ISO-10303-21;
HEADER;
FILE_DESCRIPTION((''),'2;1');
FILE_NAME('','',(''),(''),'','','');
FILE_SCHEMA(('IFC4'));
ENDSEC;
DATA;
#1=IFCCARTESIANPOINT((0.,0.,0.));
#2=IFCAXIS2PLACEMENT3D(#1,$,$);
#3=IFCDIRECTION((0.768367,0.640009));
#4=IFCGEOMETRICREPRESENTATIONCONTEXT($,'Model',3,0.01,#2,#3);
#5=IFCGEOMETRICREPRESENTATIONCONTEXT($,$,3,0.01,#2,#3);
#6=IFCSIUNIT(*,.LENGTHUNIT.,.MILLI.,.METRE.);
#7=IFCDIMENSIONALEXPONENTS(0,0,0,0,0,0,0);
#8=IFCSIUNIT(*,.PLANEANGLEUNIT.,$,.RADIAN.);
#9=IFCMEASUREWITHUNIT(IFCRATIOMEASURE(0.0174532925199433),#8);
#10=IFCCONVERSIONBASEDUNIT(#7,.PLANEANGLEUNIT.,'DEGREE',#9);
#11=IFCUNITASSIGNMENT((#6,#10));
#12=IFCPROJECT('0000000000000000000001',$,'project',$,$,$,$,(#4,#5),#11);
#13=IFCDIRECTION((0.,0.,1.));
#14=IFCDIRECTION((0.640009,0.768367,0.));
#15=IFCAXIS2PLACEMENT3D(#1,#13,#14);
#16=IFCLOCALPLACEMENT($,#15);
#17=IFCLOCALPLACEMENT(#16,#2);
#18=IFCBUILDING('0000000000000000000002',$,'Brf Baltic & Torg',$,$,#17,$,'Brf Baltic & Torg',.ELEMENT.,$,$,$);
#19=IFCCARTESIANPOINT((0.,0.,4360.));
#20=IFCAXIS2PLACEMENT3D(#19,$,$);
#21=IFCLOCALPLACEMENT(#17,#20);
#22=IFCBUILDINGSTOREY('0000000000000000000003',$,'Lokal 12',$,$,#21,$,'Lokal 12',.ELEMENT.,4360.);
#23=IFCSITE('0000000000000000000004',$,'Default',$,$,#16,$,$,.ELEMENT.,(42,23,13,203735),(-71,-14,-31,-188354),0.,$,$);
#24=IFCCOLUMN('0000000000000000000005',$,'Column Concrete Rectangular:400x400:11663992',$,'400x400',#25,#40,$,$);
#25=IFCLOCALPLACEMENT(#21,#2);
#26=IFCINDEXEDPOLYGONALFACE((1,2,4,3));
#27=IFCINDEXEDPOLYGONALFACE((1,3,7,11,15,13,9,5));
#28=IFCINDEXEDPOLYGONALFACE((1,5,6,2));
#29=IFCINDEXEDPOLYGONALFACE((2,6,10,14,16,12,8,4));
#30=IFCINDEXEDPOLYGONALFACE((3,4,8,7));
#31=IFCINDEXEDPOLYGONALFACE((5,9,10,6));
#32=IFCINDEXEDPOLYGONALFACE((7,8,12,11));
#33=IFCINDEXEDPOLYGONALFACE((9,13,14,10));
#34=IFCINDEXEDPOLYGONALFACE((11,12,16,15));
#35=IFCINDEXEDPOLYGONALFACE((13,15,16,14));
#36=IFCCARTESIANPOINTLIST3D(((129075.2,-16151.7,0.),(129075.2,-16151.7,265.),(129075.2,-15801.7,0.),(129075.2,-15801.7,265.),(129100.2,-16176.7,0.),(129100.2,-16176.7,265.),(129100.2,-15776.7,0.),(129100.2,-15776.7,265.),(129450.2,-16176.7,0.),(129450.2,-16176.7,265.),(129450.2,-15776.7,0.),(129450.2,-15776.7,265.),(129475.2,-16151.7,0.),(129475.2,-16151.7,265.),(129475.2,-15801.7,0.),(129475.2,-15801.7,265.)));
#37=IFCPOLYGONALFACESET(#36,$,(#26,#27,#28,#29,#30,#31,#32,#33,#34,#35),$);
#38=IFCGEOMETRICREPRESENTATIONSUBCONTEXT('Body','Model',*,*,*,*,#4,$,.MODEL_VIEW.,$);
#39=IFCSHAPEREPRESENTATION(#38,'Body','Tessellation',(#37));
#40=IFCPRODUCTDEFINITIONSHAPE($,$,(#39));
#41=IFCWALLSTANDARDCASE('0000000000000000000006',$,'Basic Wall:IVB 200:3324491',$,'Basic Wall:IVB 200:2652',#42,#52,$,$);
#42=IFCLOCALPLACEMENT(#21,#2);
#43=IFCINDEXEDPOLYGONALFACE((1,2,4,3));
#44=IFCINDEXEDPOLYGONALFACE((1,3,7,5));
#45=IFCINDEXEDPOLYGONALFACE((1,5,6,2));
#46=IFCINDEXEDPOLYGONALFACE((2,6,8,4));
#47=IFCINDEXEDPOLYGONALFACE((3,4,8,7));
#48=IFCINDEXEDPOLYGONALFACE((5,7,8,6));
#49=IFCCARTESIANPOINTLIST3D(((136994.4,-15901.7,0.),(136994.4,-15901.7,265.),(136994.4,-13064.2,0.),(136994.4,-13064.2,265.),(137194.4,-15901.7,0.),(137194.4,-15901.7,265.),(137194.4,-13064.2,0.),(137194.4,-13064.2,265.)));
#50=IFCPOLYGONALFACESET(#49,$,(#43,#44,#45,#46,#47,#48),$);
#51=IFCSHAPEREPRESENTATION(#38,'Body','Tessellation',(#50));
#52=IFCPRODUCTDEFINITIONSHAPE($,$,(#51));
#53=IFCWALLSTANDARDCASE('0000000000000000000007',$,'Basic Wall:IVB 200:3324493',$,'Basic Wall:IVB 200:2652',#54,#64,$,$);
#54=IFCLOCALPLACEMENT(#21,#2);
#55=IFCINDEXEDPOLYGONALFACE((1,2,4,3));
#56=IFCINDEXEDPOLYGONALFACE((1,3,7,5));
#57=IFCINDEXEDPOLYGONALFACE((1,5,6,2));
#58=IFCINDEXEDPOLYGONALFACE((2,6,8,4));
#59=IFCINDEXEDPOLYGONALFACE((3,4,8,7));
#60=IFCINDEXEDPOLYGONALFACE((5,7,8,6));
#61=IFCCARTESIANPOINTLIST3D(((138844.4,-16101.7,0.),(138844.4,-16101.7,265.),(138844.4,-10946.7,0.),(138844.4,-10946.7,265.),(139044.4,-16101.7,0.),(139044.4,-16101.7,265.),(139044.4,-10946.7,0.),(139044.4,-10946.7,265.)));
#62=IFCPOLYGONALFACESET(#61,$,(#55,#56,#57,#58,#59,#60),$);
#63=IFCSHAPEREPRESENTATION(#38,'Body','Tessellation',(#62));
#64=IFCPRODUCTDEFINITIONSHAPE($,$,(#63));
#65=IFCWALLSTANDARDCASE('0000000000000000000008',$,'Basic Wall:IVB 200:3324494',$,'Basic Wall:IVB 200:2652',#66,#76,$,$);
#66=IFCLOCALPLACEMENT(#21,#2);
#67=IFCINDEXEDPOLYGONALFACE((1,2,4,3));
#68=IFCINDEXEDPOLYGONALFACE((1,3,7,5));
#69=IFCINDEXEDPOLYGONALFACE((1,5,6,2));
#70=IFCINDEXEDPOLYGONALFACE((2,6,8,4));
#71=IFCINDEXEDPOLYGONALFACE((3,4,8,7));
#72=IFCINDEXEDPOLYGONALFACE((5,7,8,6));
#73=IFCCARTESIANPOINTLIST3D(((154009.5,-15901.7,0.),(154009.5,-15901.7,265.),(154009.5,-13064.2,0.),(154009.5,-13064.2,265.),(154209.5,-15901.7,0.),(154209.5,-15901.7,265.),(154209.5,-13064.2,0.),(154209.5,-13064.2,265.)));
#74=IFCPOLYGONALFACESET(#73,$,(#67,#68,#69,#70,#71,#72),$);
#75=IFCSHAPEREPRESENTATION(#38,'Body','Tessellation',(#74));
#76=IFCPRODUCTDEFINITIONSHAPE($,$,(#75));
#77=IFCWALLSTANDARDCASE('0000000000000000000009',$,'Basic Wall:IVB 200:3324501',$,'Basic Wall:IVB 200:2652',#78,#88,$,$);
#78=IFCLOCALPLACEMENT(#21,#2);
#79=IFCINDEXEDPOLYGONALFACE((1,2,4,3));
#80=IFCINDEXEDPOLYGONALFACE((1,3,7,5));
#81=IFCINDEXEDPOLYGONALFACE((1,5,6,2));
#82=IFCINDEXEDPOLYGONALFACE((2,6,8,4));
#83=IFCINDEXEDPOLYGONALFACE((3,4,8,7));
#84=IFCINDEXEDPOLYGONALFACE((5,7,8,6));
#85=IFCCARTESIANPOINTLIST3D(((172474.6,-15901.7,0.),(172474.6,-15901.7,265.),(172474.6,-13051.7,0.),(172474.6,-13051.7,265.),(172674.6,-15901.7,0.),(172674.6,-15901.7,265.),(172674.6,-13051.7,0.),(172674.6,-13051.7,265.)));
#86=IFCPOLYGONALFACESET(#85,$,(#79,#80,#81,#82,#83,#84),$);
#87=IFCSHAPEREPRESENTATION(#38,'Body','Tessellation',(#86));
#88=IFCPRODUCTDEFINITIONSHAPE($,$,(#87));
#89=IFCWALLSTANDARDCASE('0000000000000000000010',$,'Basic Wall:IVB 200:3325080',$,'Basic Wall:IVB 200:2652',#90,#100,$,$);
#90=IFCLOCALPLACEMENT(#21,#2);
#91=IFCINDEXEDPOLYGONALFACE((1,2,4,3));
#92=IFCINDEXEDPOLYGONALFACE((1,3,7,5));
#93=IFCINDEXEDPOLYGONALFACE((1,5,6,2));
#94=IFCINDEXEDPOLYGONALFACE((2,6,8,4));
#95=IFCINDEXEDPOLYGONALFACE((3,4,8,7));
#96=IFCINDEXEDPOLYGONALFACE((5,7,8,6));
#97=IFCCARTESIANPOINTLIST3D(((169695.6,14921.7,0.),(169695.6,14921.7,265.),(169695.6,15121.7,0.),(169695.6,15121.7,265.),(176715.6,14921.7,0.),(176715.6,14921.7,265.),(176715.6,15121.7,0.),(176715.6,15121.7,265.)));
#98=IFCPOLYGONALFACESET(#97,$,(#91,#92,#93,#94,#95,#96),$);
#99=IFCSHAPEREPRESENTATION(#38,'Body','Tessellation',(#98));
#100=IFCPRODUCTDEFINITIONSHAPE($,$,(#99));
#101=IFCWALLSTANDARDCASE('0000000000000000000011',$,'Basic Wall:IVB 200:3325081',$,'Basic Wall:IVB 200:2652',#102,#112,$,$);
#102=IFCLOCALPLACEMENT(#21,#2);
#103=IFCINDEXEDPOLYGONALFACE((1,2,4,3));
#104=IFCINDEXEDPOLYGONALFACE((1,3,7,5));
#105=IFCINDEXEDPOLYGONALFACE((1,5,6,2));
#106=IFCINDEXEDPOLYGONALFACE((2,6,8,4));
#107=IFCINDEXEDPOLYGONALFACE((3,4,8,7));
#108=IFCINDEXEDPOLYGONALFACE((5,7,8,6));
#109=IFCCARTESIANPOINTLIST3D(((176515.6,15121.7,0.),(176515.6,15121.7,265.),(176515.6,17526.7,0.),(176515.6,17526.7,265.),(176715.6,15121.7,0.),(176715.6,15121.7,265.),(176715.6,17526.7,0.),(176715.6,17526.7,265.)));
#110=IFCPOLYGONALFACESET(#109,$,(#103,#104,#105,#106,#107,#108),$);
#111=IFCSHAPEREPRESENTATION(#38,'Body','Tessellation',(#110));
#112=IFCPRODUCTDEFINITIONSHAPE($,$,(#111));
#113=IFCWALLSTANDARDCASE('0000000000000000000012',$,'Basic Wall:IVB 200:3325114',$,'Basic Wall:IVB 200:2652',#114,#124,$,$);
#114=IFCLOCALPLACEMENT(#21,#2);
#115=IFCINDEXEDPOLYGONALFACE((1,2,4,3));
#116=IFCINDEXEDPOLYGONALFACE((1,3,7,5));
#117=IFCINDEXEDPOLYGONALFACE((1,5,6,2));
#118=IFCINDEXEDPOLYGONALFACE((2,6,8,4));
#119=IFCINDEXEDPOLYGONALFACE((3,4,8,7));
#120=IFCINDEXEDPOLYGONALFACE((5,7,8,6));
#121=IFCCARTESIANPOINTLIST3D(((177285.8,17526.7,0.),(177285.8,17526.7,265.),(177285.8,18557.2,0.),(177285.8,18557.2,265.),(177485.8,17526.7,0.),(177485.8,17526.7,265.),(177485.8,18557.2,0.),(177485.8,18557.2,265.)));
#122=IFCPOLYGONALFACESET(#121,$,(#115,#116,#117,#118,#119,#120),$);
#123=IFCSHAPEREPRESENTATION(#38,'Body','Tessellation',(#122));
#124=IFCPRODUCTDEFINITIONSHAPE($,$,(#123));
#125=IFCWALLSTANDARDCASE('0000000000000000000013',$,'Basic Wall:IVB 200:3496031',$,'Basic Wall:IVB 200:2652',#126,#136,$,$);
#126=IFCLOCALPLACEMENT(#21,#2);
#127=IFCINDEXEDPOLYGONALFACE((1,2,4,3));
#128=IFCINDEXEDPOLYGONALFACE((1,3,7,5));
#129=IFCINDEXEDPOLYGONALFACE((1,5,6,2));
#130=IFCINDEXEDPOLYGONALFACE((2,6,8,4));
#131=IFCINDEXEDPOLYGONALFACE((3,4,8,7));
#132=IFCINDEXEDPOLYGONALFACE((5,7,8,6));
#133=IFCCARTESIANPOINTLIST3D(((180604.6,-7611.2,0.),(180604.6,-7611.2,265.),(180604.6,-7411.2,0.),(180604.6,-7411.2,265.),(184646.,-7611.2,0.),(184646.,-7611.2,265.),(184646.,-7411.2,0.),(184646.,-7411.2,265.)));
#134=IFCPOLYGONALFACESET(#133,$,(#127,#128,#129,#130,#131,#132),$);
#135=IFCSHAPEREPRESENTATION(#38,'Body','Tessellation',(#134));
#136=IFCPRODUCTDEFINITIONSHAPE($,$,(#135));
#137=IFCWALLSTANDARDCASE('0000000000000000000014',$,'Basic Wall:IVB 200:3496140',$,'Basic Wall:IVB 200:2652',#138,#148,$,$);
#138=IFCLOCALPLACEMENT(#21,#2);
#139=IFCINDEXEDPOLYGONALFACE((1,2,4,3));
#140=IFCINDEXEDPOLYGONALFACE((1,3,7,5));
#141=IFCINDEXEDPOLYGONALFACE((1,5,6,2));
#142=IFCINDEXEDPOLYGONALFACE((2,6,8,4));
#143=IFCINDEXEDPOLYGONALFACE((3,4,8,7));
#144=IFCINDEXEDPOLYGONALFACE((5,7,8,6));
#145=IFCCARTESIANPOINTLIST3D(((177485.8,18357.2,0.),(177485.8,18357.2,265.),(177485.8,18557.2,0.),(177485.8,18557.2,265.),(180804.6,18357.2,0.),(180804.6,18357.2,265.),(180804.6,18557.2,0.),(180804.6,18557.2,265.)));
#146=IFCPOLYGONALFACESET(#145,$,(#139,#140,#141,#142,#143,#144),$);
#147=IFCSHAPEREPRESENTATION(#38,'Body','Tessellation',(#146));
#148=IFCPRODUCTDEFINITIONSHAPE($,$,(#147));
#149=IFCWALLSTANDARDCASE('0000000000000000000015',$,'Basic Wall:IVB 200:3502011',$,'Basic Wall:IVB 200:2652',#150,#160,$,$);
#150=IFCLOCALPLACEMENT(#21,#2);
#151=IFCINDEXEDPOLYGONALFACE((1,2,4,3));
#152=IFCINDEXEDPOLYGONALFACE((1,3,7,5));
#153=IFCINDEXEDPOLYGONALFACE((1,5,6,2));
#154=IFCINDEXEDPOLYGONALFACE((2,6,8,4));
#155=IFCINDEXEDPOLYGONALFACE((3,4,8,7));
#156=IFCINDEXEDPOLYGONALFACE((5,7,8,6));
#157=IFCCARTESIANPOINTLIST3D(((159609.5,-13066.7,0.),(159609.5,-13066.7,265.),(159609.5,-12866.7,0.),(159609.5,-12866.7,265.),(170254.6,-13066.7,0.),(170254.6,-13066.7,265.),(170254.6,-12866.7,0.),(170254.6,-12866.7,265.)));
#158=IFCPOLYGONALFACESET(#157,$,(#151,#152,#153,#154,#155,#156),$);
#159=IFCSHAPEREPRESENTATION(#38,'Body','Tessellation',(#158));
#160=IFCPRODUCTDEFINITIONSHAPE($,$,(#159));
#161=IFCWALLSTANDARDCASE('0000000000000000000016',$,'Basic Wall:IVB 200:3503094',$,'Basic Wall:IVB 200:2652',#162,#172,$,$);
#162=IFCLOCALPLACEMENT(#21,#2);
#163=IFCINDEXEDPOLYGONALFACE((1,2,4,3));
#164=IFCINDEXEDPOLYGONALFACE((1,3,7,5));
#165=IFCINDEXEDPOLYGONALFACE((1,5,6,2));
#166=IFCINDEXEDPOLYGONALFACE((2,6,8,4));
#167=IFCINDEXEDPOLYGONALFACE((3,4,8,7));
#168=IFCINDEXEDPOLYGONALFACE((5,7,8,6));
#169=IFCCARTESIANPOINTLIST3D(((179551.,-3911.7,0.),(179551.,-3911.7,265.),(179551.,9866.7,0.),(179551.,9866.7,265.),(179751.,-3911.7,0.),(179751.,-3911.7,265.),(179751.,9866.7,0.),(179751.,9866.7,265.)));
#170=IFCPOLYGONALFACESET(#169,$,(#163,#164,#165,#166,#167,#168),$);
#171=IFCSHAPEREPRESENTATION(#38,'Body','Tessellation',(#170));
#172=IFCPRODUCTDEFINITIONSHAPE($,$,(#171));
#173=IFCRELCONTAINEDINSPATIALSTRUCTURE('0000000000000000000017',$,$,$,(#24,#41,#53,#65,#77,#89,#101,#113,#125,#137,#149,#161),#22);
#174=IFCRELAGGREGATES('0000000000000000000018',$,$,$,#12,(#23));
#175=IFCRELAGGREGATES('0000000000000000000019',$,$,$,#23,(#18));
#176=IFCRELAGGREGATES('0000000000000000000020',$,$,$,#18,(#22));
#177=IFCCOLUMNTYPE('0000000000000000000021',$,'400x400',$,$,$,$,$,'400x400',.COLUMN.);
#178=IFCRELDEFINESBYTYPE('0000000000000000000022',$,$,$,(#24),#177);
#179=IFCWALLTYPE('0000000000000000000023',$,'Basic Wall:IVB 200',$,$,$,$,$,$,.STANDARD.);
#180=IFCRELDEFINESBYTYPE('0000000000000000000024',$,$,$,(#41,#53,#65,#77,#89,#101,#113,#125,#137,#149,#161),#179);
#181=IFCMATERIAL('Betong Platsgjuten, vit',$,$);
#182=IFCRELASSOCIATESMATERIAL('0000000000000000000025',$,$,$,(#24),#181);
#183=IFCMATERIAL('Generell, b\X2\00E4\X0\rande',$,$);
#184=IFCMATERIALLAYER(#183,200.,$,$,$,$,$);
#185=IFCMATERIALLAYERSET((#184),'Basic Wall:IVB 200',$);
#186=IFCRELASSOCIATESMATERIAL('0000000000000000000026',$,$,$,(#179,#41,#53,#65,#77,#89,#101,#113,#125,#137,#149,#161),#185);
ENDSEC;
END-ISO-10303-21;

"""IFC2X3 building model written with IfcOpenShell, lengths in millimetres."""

from ifc_helpers import new_model, entity, si_unit, converted_unit, direction, frame, frame_2d, origin, place, context, subcontext, project, spatial, polyline, rectangle, outline, extrude, clip, halfspace, source, transform, mapped, material, layer, layer_set, layer_usage, type_object, type_shapes, element, save


model = new_model("IFC2X3")

# Units and contexts
model_context = context("Model", 3, precision=0.01, world=origin(), true_north=direction((0.768367, 0.640009)))
context_of_model = context(None, 3, precision=0.01, world=origin(), true_north=direction((0.768367, 0.640009)))
body_context = subcontext(model_context, "Body", "Model", "MODEL_VIEW")
ifc_project = project(units=[si_unit("LENGTHUNIT", "METRE", prefix="MILLI"), converted_unit("PLANEANGLEUNIT", "DEGREE", entity("IfcRatioMeasure", 0.0174532925199433), si_unit("PLANEANGLEUNIT", "RADIAN"), dimensions=[0, 0, 0, 0, 0, 0, 0])], contexts=[model_context, context_of_model])

# Site, building, storey
site_placement = place(None, frame((0.0, 0.0, 0.0), z_axis=(0.0, 0.0, 1.0), x_axis=(0.640009, 0.768367, 0.0)))
site = spatial("IfcSite", under=ifc_project, at=site_placement, Name="Default", CompositionType="ELEMENT", RefLatitude=(42, 23, 13, 203735), RefLongitude=(-71, -14, -31, -188354), RefElevation=0.0)
building_placement = place(site_placement, origin())
building = spatial("IfcBuilding", under=site, at=building_placement, Name="Brf Baltic & Torg", LongName="Brf Baltic & Torg", CompositionType="ELEMENT")
storey_placement = place(building_placement, frame((0.0, 0.0, 4360.0)))
storey = spatial("IfcBuildingStorey", under=building, at=storey_placement, Name="Lokal 12", LongName="Lokal 12", CompositionType="ELEMENT", Elevation=4360.0)

# Column
ifc_material_1 = material(Name="Betong Platsgjuten, vit")
column_type = type_object("IfcColumnType", Name="400x400", ElementType="400x400", PredefinedType="COLUMN")
shared_shape = source(origin(), body_context, "Body", "SweptSolid", [
    extrude(outline(polyline([(-175.0, -200.0), (175.0, -200.0), (200.0, -175.0), (200.0, 175.0), (175.0, 200.0), (-175.0, 200.0), (-200.0, 175.0), (-200.0, -175.0), (-175.0, -200.0)])), frame((0.0, 0.0, 4360.0), z_axis=(0.0, 0.0, 1.0), x_axis=(0.0, -1.0, 0.0)), (0.0, 0.0, 1.0), 265.0),
])
type_shapes(column_type, [shared_shape])
column_placement = place(storey_placement, frame((129275.2, -15976.7, -4360.0)))
element("IfcColumn", 1, at=column_placement, inside=storey, type_object=column_type, material=ifc_material_1, Name="Column Concrete Rectangular:400x400:11663992", ObjectType="400x400", context=body_context, shape_type="MappedRepresentation", body=[
    mapped(shared_shape, transform((0.0, 0.0, 0.0), scale=1.0)),
])

# Shared definitions
ifc_material_2 = material(Name="Generell, bärande")
ifc_layer_1 = layer(ifc_material_2, 200.0)
ifc_layer_set_1 = layer_set([ifc_layer_1], Name="Basic Wall:IVB 200")
wall_type_1 = type_object("IfcWallType", Name="Basic Wall:IVB 200", PredefinedType="STANDARD", material=ifc_layer_set_1)

# Walls
ifc_layer_usage_1 = layer_usage(ifc_layer_set_1, "AXIS2", "NEGATIVE", 100.0)
wall_1_placement = place(storey_placement, frame((137094.4, -15901.7, 0.0), z_axis=(0.0, 0.0, 1.0), x_axis=(0.0, 1.0, 0.0)))
element("IfcWallStandardCase", 2, at=wall_1_placement, inside=storey, type_object=wall_type_1, material=ifc_layer_usage_1, Name="Basic Wall:IVB 200:3324491", ObjectType="Basic Wall:IVB 200:2652", context=body_context, shape_type="Clipping", body=[
    clip(extrude(rectangle(XDim=2837.5, YDim=200.0, at=frame_2d((1418.8, 0.0), x_axis=(-1.0, 0.0))), origin(), (0.0, 0.0, 1.0), 265.0), halfspace(frame((0.0, 0.0, -2710.0)), True)),
])
ifc_layer_usage_2 = layer_usage(ifc_layer_set_1, "AXIS2", "NEGATIVE", 100.0)
wall_2_placement = place(storey_placement, frame((138944.4, -10946.7, 0.0), z_axis=(0.0, 0.0, 1.0), x_axis=(0.0, -1.0, 0.0)))
element("IfcWallStandardCase", 3, at=wall_2_placement, inside=storey, type_object=wall_type_1, material=ifc_layer_usage_2, Name="Basic Wall:IVB 200:3324493", ObjectType="Basic Wall:IVB 200:2652", context=body_context, shape_type="Clipping", body=[
    clip(extrude(rectangle(XDim=5155.0, YDim=200.0, at=frame_2d((2577.5, 0.0), x_axis=(-1.0, 0.0))), origin(), (0.0, 0.0, 1.0), 265.0), halfspace(frame((0.0, 0.0, -2710.0)), True)),
])
ifc_layer_usage_3 = layer_usage(ifc_layer_set_1, "AXIS2", "NEGATIVE", 100.0)
wall_3_placement = place(storey_placement, frame((154109.5, -15901.7, 0.0), z_axis=(0.0, 0.0, 1.0), x_axis=(0.0, 1.0, 0.0)))
element("IfcWallStandardCase", 4, at=wall_3_placement, inside=storey, type_object=wall_type_1, material=ifc_layer_usage_3, Name="Basic Wall:IVB 200:3324494", ObjectType="Basic Wall:IVB 200:2652", context=body_context, shape_type="Clipping", body=[
    clip(extrude(rectangle(XDim=2837.5, YDim=200.0, at=frame_2d((1418.7, 0.0), x_axis=(-1.0, 0.0))), origin(), (0.0, 0.0, 1.0), 265.0), halfspace(frame((0.0, 0.0, -2710.0)), True)),
])
ifc_layer_usage_4 = layer_usage(ifc_layer_set_1, "AXIS2", "POSITIVE", -100.0)
wall_4_placement = place(storey_placement, frame((172574.6, -15901.7, 0.0), z_axis=(0.0, 0.0, 1.0), x_axis=(0.0, 1.0, 0.0)))
element("IfcWallStandardCase", 5, at=wall_4_placement, inside=storey, type_object=wall_type_1, material=ifc_layer_usage_4, Name="Basic Wall:IVB 200:3324501", ObjectType="Basic Wall:IVB 200:2652", context=body_context, shape_type="Clipping", body=[
    clip(extrude(rectangle(XDim=2850.0, YDim=200.0, at=frame_2d((1425.0, 0.0), x_axis=(-1.0, 0.0))), origin(), (0.0, 0.0, 1.0), 265.0), halfspace(frame((0.0, 0.0, -2710.0)), True)),
])

# Walls
ifc_layer_usage_5 = layer_usage(ifc_layer_set_1, "AXIS2", "NEGATIVE", 100.0)
wall_5_placement = place(storey_placement, frame((169695.6, 15021.7, 0.0)))
element("IfcWallStandardCase", 6, at=wall_5_placement, inside=storey, type_object=wall_type_1, material=ifc_layer_usage_5, Name="Basic Wall:IVB 200:3325080", ObjectType="Basic Wall:IVB 200:2652", context=body_context, shape_type="Clipping", body=[
    clip(extrude(rectangle(XDim=7020.0, YDim=200.0, at=frame_2d((3510.0, 0.0), x_axis=(-1.0, 0.0))), origin(), (0.0, 0.0, 1.0), 265.0), halfspace(frame((0.0, 0.0, -2710.0)), True)),
])
ifc_layer_usage_6 = layer_usage(ifc_layer_set_1, "AXIS2", "NEGATIVE", 100.0)
wall_6_placement = place(storey_placement, frame((176615.6, 15121.7, 0.0), z_axis=(0.0, 0.0, 1.0), x_axis=(0.0, 1.0, 0.0)))
element("IfcWallStandardCase", 7, at=wall_6_placement, inside=storey, type_object=wall_type_1, material=ifc_layer_usage_6, Name="Basic Wall:IVB 200:3325081", ObjectType="Basic Wall:IVB 200:2652", context=body_context, shape_type="Clipping", body=[
    clip(extrude(rectangle(XDim=2405.0, YDim=200.0, at=frame_2d((1202.5, 0.0), x_axis=(-1.0, 0.0))), origin(), (0.0, 0.0, 1.0), 265.0), halfspace(frame((0.0, 0.0, -2710.0)), True)),
])
ifc_layer_usage_7 = layer_usage(ifc_layer_set_1, "AXIS2", "NEGATIVE", 100.0)
wall_7_placement = place(storey_placement, frame((177385.8, 17526.7, 0.0), z_axis=(0.0, 0.0, 1.0), x_axis=(0.0, 1.0, 0.0)))
element("IfcWallStandardCase", 8, at=wall_7_placement, inside=storey, type_object=wall_type_1, material=ifc_layer_usage_7, Name="Basic Wall:IVB 200:3325114", ObjectType="Basic Wall:IVB 200:2652", context=body_context, shape_type="Clipping", body=[
    clip(extrude(rectangle(XDim=1030.5, YDim=200.0, at=frame_2d((515.2, 0.0), x_axis=(-1.0, 0.0))), origin(), (0.0, 0.0, 1.0), 265.0), halfspace(frame((0.0, 0.0, -2710.0)), True)),
])
ifc_layer_usage_8 = layer_usage(ifc_layer_set_1, "AXIS2", "NEGATIVE", 100.0)
wall_8_placement = place(storey_placement, frame((180604.6, -7511.2, 0.0)))
element("IfcWallStandardCase", 9, at=wall_8_placement, inside=storey, type_object=wall_type_1, material=ifc_layer_usage_8, Name="Basic Wall:IVB 200:3496031", ObjectType="Basic Wall:IVB 200:2652", context=body_context, shape_type="Clipping", body=[
    clip(extrude(rectangle(XDim=4041.4, YDim=200.0, at=frame_2d((2020.7, 0.0), x_axis=(-1.0, 0.0))), origin(), (0.0, 0.0, 1.0), 265.0), halfspace(frame((0.0, 0.0, -2710.0)), True)),
])
ifc_layer_usage_9 = layer_usage(ifc_layer_set_1, "AXIS2", "NEGATIVE", 100.0)
wall_9_placement = place(storey_placement, frame((177485.8, 18457.2, 0.0)))
element("IfcWallStandardCase", 10, at=wall_9_placement, inside=storey, type_object=wall_type_1, material=ifc_layer_usage_9, Name="Basic Wall:IVB 200:3496140", ObjectType="Basic Wall:IVB 200:2652", context=body_context, shape_type="Clipping", body=[
    clip(extrude(rectangle(XDim=3318.8, YDim=200.0, at=frame_2d((1659.4, 0.0), x_axis=(-1.0, 0.0))), origin(), (0.0, 0.0, 1.0), 265.0), halfspace(frame((0.0, 0.0, -2710.0)), True)),
])
ifc_layer_usage_10 = layer_usage(ifc_layer_set_1, "AXIS2", "NEGATIVE", 100.0)
wall_10_placement = place(storey_placement, frame((170254.6, -12966.7, 0.0), z_axis=(0.0, 0.0, 1.0), x_axis=(-1.0, 0.0, 0.0)))
element("IfcWallStandardCase", 11, at=wall_10_placement, inside=storey, type_object=wall_type_1, material=ifc_layer_usage_10, Name="Basic Wall:IVB 200:3502011", ObjectType="Basic Wall:IVB 200:2652", context=body_context, shape_type="Clipping", body=[
    clip(extrude(rectangle(XDim=10645.0, YDim=200.0, at=frame_2d((5322.5, 0.0), x_axis=(-1.0, 0.0))), origin(), (0.0, 0.0, 1.0), 265.0), halfspace(frame((0.0, 0.0, -2710.0)), True)),
])
ifc_layer_usage_11 = layer_usage(ifc_layer_set_1, "AXIS2", "NEGATIVE", 100.0)
wall_11_placement = place(storey_placement, frame((179651.0, 9866.7, 0.0), z_axis=(0.0, 0.0, 1.0), x_axis=(0.0, -1.0, 0.0)))
element("IfcWallStandardCase", 12, at=wall_11_placement, inside=storey, type_object=wall_type_1, material=ifc_layer_usage_11, Name="Basic Wall:IVB 200:3503094", ObjectType="Basic Wall:IVB 200:2652", context=body_context, shape_type="Clipping", body=[
    clip(extrude(rectangle(XDim=13778.4, YDim=200.0, at=frame_2d((6889.2, 0.0), x_axis=(-1.0, 0.0))), origin(), (0.0, 0.0, 1.0), 265.0), halfspace(frame((0.0, 0.0, -2710.0)), True)),
])

save(model, "model.ifc")
